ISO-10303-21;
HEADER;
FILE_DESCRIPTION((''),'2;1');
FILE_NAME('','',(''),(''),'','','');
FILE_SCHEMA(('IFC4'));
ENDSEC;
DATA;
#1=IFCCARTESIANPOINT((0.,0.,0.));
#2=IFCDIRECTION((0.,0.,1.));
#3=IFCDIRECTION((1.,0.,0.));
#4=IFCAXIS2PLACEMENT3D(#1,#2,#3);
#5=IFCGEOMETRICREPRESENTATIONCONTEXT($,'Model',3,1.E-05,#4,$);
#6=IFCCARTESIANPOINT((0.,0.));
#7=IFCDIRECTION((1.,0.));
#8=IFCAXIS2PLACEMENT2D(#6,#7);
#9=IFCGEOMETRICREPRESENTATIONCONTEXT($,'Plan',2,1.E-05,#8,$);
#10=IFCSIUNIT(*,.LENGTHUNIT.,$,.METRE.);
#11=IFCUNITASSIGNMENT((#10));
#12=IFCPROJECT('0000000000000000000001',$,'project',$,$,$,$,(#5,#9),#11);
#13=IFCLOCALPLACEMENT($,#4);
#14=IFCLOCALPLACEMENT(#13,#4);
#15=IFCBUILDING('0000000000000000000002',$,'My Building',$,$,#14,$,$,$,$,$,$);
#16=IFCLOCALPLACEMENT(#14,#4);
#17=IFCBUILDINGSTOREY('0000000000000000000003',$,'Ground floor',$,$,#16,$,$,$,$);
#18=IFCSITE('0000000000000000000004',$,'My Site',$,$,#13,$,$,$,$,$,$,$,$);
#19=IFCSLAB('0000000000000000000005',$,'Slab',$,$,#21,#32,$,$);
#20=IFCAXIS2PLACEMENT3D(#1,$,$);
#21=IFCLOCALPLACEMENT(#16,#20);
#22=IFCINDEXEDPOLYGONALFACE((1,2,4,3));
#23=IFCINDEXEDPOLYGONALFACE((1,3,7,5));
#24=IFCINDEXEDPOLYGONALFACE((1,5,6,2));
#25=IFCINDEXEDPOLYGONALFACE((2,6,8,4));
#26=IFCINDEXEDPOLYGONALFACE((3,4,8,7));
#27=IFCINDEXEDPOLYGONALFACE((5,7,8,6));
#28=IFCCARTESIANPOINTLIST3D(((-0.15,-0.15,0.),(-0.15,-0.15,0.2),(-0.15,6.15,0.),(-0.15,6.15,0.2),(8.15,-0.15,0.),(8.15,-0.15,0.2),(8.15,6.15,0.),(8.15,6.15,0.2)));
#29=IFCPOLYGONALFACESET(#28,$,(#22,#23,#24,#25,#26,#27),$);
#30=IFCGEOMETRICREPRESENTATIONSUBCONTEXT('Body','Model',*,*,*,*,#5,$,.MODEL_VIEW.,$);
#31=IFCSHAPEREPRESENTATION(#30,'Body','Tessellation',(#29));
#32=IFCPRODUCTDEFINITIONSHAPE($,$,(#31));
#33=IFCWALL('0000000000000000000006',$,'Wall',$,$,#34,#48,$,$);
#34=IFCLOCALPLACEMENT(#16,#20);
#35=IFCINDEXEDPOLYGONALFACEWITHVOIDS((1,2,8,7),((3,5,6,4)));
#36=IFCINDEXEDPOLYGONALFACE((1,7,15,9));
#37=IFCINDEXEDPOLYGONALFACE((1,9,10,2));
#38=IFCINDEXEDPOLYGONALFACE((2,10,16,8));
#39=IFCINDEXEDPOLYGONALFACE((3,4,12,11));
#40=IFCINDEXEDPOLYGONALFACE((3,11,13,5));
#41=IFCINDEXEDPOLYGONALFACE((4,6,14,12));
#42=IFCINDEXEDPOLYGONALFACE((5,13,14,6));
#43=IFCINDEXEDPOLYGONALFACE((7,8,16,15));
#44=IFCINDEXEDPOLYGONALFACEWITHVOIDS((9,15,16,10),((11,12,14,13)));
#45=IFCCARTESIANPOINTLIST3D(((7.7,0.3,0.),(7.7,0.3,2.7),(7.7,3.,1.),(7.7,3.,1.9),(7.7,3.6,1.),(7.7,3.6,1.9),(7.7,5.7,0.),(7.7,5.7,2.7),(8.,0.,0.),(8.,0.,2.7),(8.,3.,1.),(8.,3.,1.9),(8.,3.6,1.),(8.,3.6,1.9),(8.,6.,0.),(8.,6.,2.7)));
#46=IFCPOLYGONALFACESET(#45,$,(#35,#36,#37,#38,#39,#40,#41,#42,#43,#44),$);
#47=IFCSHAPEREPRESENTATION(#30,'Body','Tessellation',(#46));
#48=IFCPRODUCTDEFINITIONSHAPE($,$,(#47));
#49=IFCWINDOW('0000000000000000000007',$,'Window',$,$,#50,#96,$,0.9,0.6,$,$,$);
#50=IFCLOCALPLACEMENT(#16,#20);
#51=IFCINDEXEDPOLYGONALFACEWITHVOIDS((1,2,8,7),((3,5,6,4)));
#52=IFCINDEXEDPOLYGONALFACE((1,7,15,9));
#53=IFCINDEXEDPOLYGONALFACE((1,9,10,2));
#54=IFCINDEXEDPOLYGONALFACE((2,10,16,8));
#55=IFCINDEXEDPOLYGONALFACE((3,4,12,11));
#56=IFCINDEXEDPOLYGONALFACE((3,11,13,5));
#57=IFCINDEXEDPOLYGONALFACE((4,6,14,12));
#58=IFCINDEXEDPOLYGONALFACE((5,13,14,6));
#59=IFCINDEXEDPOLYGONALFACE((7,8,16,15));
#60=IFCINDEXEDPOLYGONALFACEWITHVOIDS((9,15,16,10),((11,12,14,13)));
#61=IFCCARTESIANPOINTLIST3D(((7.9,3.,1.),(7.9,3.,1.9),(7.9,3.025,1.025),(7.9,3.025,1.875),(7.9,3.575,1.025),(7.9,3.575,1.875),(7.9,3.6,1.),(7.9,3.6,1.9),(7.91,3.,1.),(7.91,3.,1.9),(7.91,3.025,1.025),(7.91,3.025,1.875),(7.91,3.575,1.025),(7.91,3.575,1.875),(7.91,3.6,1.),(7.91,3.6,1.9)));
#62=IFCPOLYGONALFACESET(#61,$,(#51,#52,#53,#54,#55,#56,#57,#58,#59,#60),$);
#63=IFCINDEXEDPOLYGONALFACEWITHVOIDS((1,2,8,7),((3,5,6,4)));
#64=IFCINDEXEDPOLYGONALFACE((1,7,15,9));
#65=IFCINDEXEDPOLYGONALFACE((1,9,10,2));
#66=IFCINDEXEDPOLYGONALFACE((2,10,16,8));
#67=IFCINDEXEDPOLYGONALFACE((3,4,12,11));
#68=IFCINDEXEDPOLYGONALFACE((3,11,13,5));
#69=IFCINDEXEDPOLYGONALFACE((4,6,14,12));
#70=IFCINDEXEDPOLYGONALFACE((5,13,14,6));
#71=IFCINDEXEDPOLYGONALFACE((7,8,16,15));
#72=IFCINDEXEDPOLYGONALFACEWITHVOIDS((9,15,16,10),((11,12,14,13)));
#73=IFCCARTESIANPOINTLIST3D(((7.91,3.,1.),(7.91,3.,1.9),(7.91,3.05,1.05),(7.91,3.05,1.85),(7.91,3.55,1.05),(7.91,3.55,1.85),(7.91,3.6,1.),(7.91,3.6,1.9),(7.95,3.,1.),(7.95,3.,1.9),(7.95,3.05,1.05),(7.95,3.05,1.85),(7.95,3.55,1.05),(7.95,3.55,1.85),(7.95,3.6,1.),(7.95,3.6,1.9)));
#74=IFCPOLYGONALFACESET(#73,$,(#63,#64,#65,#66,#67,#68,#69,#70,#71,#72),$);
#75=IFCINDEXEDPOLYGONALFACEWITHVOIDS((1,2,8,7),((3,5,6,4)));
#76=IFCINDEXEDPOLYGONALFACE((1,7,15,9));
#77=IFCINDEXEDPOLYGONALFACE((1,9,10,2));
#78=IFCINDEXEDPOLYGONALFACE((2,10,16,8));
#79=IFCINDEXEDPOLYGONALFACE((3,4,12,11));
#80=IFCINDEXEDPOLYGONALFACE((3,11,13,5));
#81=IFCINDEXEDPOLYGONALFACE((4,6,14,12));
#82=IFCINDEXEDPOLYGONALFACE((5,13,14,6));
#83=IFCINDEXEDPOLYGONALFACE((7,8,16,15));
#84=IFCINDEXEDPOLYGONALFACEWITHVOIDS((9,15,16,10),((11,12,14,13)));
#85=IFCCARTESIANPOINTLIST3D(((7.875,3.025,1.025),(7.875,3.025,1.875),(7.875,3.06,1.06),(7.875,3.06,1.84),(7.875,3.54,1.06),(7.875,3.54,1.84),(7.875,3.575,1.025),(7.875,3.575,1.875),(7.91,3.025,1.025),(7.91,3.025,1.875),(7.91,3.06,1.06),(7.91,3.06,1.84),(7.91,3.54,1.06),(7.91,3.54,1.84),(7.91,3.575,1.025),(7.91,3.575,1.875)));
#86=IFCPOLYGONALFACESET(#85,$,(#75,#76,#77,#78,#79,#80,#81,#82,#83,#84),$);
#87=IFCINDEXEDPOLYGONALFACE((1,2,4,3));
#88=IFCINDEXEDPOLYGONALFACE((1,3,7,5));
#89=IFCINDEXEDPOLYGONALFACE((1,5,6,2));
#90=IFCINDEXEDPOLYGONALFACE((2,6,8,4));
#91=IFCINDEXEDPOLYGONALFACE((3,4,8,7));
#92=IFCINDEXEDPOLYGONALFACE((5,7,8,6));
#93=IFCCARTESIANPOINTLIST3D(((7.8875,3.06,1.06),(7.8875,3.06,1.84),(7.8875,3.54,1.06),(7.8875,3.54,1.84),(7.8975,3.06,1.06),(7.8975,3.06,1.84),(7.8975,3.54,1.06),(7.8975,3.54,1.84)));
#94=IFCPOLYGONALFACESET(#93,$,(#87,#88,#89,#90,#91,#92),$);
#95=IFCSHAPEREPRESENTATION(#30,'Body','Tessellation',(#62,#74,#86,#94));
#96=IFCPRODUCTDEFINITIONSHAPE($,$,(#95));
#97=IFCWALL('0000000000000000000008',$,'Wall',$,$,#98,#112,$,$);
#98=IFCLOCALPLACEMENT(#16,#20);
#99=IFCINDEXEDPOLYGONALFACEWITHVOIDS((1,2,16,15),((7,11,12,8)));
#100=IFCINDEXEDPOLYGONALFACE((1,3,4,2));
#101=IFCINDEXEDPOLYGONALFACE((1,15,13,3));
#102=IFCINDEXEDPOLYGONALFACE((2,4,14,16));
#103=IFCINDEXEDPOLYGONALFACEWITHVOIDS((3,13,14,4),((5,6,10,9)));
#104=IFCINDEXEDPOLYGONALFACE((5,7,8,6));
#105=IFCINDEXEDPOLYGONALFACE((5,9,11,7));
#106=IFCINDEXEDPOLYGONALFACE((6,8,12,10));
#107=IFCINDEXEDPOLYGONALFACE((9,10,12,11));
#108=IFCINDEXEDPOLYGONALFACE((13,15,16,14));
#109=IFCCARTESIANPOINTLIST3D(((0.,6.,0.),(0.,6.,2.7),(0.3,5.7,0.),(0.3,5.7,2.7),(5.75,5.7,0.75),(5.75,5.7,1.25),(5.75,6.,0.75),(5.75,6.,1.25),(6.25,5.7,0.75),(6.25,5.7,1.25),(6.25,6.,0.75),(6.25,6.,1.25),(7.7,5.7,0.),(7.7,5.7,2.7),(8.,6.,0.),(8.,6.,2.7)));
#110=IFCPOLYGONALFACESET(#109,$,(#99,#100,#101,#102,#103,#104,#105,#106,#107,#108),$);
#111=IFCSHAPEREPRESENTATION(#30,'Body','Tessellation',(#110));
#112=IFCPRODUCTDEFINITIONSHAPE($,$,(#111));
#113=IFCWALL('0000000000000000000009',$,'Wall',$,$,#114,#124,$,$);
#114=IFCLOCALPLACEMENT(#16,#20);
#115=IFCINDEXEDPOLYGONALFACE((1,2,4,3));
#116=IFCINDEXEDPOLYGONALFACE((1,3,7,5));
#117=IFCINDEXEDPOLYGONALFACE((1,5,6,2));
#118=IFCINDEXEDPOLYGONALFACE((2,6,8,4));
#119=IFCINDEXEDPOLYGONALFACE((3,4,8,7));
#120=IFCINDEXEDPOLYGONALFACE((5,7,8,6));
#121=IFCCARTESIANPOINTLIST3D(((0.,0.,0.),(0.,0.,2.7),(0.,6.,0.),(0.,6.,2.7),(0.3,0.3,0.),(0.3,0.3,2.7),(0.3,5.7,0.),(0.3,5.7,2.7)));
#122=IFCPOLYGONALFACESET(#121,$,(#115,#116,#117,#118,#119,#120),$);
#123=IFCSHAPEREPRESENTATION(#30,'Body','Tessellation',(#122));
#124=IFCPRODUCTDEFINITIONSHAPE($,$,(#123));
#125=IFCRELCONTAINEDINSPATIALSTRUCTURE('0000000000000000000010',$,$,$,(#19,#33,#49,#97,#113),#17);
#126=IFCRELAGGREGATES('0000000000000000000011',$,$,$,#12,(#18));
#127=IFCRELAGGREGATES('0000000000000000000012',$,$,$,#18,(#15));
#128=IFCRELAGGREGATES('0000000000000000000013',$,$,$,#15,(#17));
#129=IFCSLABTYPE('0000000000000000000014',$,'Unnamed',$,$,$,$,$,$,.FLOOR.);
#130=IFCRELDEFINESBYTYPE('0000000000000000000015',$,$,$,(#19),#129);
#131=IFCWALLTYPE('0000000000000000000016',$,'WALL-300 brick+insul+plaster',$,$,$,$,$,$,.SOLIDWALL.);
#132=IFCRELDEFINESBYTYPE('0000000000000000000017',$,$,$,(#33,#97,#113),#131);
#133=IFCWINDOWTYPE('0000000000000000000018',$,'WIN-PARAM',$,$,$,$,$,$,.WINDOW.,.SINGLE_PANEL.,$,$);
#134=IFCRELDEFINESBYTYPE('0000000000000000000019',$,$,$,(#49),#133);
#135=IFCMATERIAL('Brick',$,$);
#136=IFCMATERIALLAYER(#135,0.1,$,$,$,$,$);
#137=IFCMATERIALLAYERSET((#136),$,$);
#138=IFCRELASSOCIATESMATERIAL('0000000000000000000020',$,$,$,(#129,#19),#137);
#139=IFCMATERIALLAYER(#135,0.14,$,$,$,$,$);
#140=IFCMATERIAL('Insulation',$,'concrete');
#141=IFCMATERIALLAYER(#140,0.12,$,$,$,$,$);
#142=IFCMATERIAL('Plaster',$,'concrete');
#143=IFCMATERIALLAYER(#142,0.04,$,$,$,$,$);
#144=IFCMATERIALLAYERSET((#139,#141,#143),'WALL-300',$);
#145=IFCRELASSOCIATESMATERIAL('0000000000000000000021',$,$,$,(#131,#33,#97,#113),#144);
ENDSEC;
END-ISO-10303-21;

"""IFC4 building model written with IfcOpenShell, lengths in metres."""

from ifc_helpers import new_model, entity, si_unit, frame, origin_with_axes, origin_2d_with_axis, place, context, subcontext, project, spatial, line, indexed_curve, outline, extrude, shape, source, transform, mapped, material, layer, layer_set, layer_usage, type_object, type_shapes, element, fill, save


model = new_model("IFC4")

# Units and contexts
model_context = context("Model", 3, precision=1e-05, world=origin_with_axes())
plan_context = context("Plan", 2, precision=1e-05, world=origin_2d_with_axis())
body_context_1 = subcontext(model_context, "Body", "Model", "MODEL_VIEW")
body_context_2 = subcontext(plan_context, "Body", "Plan", "PLAN_VIEW")
ifc_project = project(units=[si_unit("LENGTHUNIT", "METRE")], contexts=[model_context, plan_context])

# Site, building, storey
site_placement = place(None, origin_with_axes())
site = spatial("IfcSite", under=ifc_project, at=site_placement, Name="My Site")
building_placement = place(site_placement, origin_with_axes())
building = spatial("IfcBuilding", under=site, at=building_placement, Name="My Building")
storey_placement = place(building_placement, origin_with_axes())
storey = spatial("IfcBuildingStorey", under=building, at=storey_placement, Name="Ground floor")

# Slab
ifc_material_1 = material(Name="Brick")
ifc_layer_1 = layer(ifc_material_1, 0.1)
ifc_layer_set_1 = layer_set([ifc_layer_1])
ifc_layer_usage_1 = layer_usage(ifc_layer_set_1, "AXIS3", "POSITIVE", 0.0)
slab_type = type_object("IfcSlabType", Name="Unnamed", PredefinedType="FLOOR", material=ifc_layer_set_1)
slab_placement = place(storey_placement, origin_with_axes())
element("IfcSlab", 1, at=slab_placement, inside=storey, type_object=slab_type, material=ifc_layer_usage_1, Name="Slab", context=body_context_1, shape_type="SweptSolid", body=[
    extrude(outline(indexed_curve([(-0.15, -0.15), (8.15, -0.15), (8.15, 6.15), (-0.15, 6.15), (-0.15, -0.15)])), None, (0.0, 0.0, 1.0), 0.2),
])

# Shared definitions
ifc_layer_2 = layer(ifc_material_1, 0.14)
ifc_material_2 = material(Name="Insulation", Category="concrete")
ifc_layer_3 = layer(ifc_material_2, 0.12)
ifc_material_3 = material(Name="Plaster", Category="concrete")
ifc_layer_4 = layer(ifc_material_3, 0.04)
ifc_layer_set_2 = layer_set([ifc_layer_2, ifc_layer_3, ifc_layer_4], Name="WALL-300")
wall_type = type_object("IfcWallType", Name="WALL-300 brick+insul+plaster", PredefinedType="SOLIDWALL", material=ifc_layer_set_2)
shared_shape_1 = source(origin_with_axes(), body_context_1, "Body", "SweptSolid", [
    extrude(outline(indexed_curve([(0.0, 0.0), (0.6, 0.0), (0.6, 0.9), (0.0, 0.9)], segments=[line(1, 2, 3, 4, 1)])), frame((0.0, -0.6, 0.0), z_axis=(0.0, -1.0, 0.0), x_axis=(1.0, 0.0, 0.0)), (0.0, 0.0, -1.0), 1.2),
])
window_type = type_object("IfcWindowType", Name="WIN-PARAM", PartitioningType="SINGLE_PANEL", PredefinedType="WINDOW")
shared_shape_2 = source(origin_with_axes(), body_context_1, "Body", "SweptSolid", [
    extrude(outline(indexed_curve([(0.0, 0.0), (0.6, 0.0), (0.6, 0.9), (0.0, 0.9)], segments=[line(1, 2, 3, 4, 1)]), holes=[indexed_curve([(0.025, 0.025), (0.575, 0.025), (0.575, 0.875), (0.025, 0.875)], segments=[line(1, 2, 3, 4, 1)])]), frame((0.0, 0.09, 0.0), z_axis=(0.0, -1.0, 0.0), x_axis=(1.0, 0.0, 0.0)), (0.0, 0.0, -1.0), 0.01),
    extrude(outline(indexed_curve([(0.0, 0.0), (0.6, 0.0), (0.6, 0.9), (0.0, 0.9)], segments=[line(1, 2, 3, 4, 1)]), holes=[indexed_curve([(0.05, 0.05), (0.55, 0.05), (0.55, 0.85), (0.05, 0.85)], segments=[line(1, 2, 3, 4, 1)])]), frame((0.0, 0.05, 0.0), z_axis=(0.0, -1.0, 0.0), x_axis=(1.0, 0.0, 0.0)), (0.0, 0.0, -1.0), 0.04),
    extrude(outline(indexed_curve([(0.0, 0.0), (0.55, 0.0), (0.55, 0.85), (0.0, 0.85)], segments=[line(1, 2, 3, 4, 1)]), holes=[indexed_curve([(0.035, 0.035), (0.515, 0.035), (0.515, 0.815), (0.035, 0.815)], segments=[line(1, 2, 3, 4, 1)])]), frame((0.025, 0.09, 0.025), z_axis=(0.0, -1.0, 0.0), x_axis=(1.0, 0.0, 0.0)), (0.0, 0.0, -1.0), 0.035),
    extrude(outline(indexed_curve([(0.035, 0.035), (0.515, 0.035), (0.515, 0.815), (0.035, 0.815)], segments=[line(1, 2, 3, 4, 1)])), frame((0.025, 0.1025, 0.025), z_axis=(0.0, -1.0, 0.0), x_axis=(1.0, 0.0, 0.0)), (0.0, 0.0, -1.0), 0.01),
])
shared_shape_3 = source(origin_with_axes(), body_context_2, "Body", "Curve2D", [
    entity("IfcIndexedPolyCurve", entity("IfcCartesianPointList2D", [[0.05, 0.05], [0.55, 0.05]])),
    entity("IfcIndexedPolyCurve", entity("IfcCartesianPointList2D", [[0.0, 0.1], [0.025, 0.1], [0.025, 0.09], [0.05, 0.09], [0.05, 0.05], [0.0, 0.05]]), [entity("IfcLineIndex", [1, 2, 3, 4, 5, 6, 1])]),
    entity("IfcIndexedPolyCurve", entity("IfcCartesianPointList2D", [[0.6, 0.1], [0.575, 0.1], [0.575, 0.09], [0.55, 0.09], [0.55, 0.05], [0.6, 0.05]]), [entity("IfcLineIndex", [1, 2, 3, 4, 5, 6, 1])]),
    entity("IfcIndexedPolyCurve", entity("IfcCartesianPointList2D", [[0.025, 0.09], [0.06, 0.09], [0.06, 0.125], [0.025, 0.125]]), [entity("IfcLineIndex", [1, 2, 3, 4, 1])]),
    entity("IfcIndexedPolyCurve", entity("IfcCartesianPointList2D", [[0.575, 0.09], [0.54, 0.09], [0.54, 0.125], [0.575, 0.125]]), [entity("IfcLineIndex", [1, 2, 3, 4, 1])]),
    entity("IfcIndexedPolyCurve", entity("IfcCartesianPointList2D", [[0.06, 0.09], [0.54, 0.09]])),
    entity("IfcIndexedPolyCurve", entity("IfcCartesianPointList2D", [[0.06, 0.125], [0.54, 0.125]])),
    entity("IfcIndexedPolyCurve", entity("IfcCartesianPointList2D", [[0.06, 0.1075], [0.54, 0.1075]])),
])
type_shapes(window_type, [shared_shape_2, shared_shape_3])

# Wall, opening, window
ifc_layer_usage_2 = layer_usage(ifc_layer_set_2, "AXIS2", "POSITIVE", 0.0)
wall_1_placement = place(storey_placement, frame((8.0, 0.0, 0.0), z_axis=(0.0, 0.0, 1.0), x_axis=(0.0, 1.0, 0.0)))
wall_1 = element("IfcWall", 2, at=wall_1_placement, inside=storey, type_object=wall_type, material=ifc_layer_usage_2, Name="Wall", context=body_context_1, shape_type="SweptSolid", body=[
    extrude(outline(indexed_curve([(0.0, 0.0), (0.3, 0.3), (5.7, 0.3), (6.0, 0.0)], segments=[line(1, 2, 3, 4, 1)])), origin_with_axes(), (0.0, 0.0, 1.0), 2.7),
])
opening_1_placement = place(wall_1_placement, frame((3.0, 0.0, 1.0), z_axis=(0.0, 0.0, 1.0), x_axis=(1.0, 0.0, 0.0)))
opening_1 = element("IfcOpeningElement", 3, at=opening_1_placement, cuts=wall_1, PredefinedType="OPENING", context=body_context_1, shape_type="MappedRepresentation", body=[
    mapped(shared_shape_1, transform((0.0, 0.0, 0.0), x_axis=(1.0, 0.0, 0.0), y_axis=(0.0, 1.0, 0.0), z_axis=(0.0, 0.0, 1.0), scale=1.0)),
])
window_1_placement = place(opening_1_placement, frame((0.0, 0.0, 0.0), z_axis=(0.0, 0.0, 1.0), x_axis=(1.0, 0.0, 0.0)))
window_1 = element("IfcWindow", 4, at=window_1_placement, inside=storey, type_object=window_type, Name="Window", OverallHeight=0.9, OverallWidth=0.6, shapes=[
    shape(body_context_1, "Body", "MappedRepresentation", [mapped(shared_shape_2, transform((0.0, 0.0, 0.0), x_axis=(1.0, 0.0, 0.0), y_axis=(0.0, 1.0, 0.0), z_axis=(0.0, 0.0, 1.0), scale=1.0))]),
    shape(body_context_2, "Body", "MappedRepresentation", [mapped(shared_shape_3, transform((0.0, 0.0, 0.0), x_axis=(1.0, 0.0, 0.0), y_axis=(0.0, 1.0, 0.0), z_axis=(0.0, 0.0, 1.0), scale=1.0))]),
])
fill(opening_1, window_1)

# Wall, opening
ifc_layer_usage_3 = layer_usage(ifc_layer_set_2, "AXIS2", "POSITIVE", 0.0)
wall_2_placement = place(storey_placement, frame((8.0, 6.0, 0.0), z_axis=(0.0, 0.0, 1.0), x_axis=(-1.0, 0.0, 0.0)))
wall_2 = element("IfcWall", 5, at=wall_2_placement, inside=storey, type_object=wall_type, material=ifc_layer_usage_3, Name="Wall", context=body_context_1, shape_type="SweptSolid", body=[
    extrude(outline(indexed_curve([(0.0, 0.0), (0.3, 0.3), (7.7, 0.3), (8.0, 0.0)], segments=[line(1, 2, 3, 4, 1)])), origin_with_axes(), (0.0, 0.0, 1.0), 2.7),
])
shared_shape_4 = source(origin_with_axes(), body_context_1, "Body", "SweptSolid", [
    extrude(outline(indexed_curve([(0.0, 0.0), (0.5, 0.0), (0.5, 0.5), (0.0, 0.5)], segments=[line(1, 2, 3, 4, 1)])), frame((-0.25, -0.6, -0.25), z_axis=(0.0, -1.0, 0.0), x_axis=(1.0, 0.0, 0.0)), (0.0, 0.0, -1.0), 1.2),
])
opening_2_placement = place(wall_2_placement, frame((2.0, 0.0, 1.0), z_axis=(0.0, 0.0, 1.0), x_axis=(1.0, 0.0, 0.0)))
element("IfcOpeningElement", 6, at=opening_2_placement, cuts=wall_2, PredefinedType="OPENING", context=body_context_1, shape_type="MappedRepresentation", body=[
    mapped(shared_shape_4, transform((0.0, 0.0, 0.0), x_axis=(1.0, 0.0, 0.0), y_axis=(0.0, 1.0, 0.0), z_axis=(0.0, 0.0, 1.0), scale=1.0)),
])

# Wall
ifc_layer_usage_4 = layer_usage(ifc_layer_set_2, "AXIS2", "POSITIVE", 0.0)
wall_3_placement = place(storey_placement, frame((0.0, 6.0, 0.0), z_axis=(0.0, 0.0, 1.0), x_axis=(0.0, -1.0, 0.0)))
element("IfcWall", 7, at=wall_3_placement, inside=storey, type_object=wall_type, material=ifc_layer_usage_4, Name="Wall", context=body_context_1, shape_type="SweptSolid", body=[
    extrude(outline(indexed_curve([(0.0, 0.0), (0.3, 0.3), (5.7, 0.3), (6.0, 0.0)], segments=[line(1, 2, 3, 4, 1)])), origin_with_axes(), (0.0, 0.0, 1.0), 2.7),
])

save(model, "model.ifc")
